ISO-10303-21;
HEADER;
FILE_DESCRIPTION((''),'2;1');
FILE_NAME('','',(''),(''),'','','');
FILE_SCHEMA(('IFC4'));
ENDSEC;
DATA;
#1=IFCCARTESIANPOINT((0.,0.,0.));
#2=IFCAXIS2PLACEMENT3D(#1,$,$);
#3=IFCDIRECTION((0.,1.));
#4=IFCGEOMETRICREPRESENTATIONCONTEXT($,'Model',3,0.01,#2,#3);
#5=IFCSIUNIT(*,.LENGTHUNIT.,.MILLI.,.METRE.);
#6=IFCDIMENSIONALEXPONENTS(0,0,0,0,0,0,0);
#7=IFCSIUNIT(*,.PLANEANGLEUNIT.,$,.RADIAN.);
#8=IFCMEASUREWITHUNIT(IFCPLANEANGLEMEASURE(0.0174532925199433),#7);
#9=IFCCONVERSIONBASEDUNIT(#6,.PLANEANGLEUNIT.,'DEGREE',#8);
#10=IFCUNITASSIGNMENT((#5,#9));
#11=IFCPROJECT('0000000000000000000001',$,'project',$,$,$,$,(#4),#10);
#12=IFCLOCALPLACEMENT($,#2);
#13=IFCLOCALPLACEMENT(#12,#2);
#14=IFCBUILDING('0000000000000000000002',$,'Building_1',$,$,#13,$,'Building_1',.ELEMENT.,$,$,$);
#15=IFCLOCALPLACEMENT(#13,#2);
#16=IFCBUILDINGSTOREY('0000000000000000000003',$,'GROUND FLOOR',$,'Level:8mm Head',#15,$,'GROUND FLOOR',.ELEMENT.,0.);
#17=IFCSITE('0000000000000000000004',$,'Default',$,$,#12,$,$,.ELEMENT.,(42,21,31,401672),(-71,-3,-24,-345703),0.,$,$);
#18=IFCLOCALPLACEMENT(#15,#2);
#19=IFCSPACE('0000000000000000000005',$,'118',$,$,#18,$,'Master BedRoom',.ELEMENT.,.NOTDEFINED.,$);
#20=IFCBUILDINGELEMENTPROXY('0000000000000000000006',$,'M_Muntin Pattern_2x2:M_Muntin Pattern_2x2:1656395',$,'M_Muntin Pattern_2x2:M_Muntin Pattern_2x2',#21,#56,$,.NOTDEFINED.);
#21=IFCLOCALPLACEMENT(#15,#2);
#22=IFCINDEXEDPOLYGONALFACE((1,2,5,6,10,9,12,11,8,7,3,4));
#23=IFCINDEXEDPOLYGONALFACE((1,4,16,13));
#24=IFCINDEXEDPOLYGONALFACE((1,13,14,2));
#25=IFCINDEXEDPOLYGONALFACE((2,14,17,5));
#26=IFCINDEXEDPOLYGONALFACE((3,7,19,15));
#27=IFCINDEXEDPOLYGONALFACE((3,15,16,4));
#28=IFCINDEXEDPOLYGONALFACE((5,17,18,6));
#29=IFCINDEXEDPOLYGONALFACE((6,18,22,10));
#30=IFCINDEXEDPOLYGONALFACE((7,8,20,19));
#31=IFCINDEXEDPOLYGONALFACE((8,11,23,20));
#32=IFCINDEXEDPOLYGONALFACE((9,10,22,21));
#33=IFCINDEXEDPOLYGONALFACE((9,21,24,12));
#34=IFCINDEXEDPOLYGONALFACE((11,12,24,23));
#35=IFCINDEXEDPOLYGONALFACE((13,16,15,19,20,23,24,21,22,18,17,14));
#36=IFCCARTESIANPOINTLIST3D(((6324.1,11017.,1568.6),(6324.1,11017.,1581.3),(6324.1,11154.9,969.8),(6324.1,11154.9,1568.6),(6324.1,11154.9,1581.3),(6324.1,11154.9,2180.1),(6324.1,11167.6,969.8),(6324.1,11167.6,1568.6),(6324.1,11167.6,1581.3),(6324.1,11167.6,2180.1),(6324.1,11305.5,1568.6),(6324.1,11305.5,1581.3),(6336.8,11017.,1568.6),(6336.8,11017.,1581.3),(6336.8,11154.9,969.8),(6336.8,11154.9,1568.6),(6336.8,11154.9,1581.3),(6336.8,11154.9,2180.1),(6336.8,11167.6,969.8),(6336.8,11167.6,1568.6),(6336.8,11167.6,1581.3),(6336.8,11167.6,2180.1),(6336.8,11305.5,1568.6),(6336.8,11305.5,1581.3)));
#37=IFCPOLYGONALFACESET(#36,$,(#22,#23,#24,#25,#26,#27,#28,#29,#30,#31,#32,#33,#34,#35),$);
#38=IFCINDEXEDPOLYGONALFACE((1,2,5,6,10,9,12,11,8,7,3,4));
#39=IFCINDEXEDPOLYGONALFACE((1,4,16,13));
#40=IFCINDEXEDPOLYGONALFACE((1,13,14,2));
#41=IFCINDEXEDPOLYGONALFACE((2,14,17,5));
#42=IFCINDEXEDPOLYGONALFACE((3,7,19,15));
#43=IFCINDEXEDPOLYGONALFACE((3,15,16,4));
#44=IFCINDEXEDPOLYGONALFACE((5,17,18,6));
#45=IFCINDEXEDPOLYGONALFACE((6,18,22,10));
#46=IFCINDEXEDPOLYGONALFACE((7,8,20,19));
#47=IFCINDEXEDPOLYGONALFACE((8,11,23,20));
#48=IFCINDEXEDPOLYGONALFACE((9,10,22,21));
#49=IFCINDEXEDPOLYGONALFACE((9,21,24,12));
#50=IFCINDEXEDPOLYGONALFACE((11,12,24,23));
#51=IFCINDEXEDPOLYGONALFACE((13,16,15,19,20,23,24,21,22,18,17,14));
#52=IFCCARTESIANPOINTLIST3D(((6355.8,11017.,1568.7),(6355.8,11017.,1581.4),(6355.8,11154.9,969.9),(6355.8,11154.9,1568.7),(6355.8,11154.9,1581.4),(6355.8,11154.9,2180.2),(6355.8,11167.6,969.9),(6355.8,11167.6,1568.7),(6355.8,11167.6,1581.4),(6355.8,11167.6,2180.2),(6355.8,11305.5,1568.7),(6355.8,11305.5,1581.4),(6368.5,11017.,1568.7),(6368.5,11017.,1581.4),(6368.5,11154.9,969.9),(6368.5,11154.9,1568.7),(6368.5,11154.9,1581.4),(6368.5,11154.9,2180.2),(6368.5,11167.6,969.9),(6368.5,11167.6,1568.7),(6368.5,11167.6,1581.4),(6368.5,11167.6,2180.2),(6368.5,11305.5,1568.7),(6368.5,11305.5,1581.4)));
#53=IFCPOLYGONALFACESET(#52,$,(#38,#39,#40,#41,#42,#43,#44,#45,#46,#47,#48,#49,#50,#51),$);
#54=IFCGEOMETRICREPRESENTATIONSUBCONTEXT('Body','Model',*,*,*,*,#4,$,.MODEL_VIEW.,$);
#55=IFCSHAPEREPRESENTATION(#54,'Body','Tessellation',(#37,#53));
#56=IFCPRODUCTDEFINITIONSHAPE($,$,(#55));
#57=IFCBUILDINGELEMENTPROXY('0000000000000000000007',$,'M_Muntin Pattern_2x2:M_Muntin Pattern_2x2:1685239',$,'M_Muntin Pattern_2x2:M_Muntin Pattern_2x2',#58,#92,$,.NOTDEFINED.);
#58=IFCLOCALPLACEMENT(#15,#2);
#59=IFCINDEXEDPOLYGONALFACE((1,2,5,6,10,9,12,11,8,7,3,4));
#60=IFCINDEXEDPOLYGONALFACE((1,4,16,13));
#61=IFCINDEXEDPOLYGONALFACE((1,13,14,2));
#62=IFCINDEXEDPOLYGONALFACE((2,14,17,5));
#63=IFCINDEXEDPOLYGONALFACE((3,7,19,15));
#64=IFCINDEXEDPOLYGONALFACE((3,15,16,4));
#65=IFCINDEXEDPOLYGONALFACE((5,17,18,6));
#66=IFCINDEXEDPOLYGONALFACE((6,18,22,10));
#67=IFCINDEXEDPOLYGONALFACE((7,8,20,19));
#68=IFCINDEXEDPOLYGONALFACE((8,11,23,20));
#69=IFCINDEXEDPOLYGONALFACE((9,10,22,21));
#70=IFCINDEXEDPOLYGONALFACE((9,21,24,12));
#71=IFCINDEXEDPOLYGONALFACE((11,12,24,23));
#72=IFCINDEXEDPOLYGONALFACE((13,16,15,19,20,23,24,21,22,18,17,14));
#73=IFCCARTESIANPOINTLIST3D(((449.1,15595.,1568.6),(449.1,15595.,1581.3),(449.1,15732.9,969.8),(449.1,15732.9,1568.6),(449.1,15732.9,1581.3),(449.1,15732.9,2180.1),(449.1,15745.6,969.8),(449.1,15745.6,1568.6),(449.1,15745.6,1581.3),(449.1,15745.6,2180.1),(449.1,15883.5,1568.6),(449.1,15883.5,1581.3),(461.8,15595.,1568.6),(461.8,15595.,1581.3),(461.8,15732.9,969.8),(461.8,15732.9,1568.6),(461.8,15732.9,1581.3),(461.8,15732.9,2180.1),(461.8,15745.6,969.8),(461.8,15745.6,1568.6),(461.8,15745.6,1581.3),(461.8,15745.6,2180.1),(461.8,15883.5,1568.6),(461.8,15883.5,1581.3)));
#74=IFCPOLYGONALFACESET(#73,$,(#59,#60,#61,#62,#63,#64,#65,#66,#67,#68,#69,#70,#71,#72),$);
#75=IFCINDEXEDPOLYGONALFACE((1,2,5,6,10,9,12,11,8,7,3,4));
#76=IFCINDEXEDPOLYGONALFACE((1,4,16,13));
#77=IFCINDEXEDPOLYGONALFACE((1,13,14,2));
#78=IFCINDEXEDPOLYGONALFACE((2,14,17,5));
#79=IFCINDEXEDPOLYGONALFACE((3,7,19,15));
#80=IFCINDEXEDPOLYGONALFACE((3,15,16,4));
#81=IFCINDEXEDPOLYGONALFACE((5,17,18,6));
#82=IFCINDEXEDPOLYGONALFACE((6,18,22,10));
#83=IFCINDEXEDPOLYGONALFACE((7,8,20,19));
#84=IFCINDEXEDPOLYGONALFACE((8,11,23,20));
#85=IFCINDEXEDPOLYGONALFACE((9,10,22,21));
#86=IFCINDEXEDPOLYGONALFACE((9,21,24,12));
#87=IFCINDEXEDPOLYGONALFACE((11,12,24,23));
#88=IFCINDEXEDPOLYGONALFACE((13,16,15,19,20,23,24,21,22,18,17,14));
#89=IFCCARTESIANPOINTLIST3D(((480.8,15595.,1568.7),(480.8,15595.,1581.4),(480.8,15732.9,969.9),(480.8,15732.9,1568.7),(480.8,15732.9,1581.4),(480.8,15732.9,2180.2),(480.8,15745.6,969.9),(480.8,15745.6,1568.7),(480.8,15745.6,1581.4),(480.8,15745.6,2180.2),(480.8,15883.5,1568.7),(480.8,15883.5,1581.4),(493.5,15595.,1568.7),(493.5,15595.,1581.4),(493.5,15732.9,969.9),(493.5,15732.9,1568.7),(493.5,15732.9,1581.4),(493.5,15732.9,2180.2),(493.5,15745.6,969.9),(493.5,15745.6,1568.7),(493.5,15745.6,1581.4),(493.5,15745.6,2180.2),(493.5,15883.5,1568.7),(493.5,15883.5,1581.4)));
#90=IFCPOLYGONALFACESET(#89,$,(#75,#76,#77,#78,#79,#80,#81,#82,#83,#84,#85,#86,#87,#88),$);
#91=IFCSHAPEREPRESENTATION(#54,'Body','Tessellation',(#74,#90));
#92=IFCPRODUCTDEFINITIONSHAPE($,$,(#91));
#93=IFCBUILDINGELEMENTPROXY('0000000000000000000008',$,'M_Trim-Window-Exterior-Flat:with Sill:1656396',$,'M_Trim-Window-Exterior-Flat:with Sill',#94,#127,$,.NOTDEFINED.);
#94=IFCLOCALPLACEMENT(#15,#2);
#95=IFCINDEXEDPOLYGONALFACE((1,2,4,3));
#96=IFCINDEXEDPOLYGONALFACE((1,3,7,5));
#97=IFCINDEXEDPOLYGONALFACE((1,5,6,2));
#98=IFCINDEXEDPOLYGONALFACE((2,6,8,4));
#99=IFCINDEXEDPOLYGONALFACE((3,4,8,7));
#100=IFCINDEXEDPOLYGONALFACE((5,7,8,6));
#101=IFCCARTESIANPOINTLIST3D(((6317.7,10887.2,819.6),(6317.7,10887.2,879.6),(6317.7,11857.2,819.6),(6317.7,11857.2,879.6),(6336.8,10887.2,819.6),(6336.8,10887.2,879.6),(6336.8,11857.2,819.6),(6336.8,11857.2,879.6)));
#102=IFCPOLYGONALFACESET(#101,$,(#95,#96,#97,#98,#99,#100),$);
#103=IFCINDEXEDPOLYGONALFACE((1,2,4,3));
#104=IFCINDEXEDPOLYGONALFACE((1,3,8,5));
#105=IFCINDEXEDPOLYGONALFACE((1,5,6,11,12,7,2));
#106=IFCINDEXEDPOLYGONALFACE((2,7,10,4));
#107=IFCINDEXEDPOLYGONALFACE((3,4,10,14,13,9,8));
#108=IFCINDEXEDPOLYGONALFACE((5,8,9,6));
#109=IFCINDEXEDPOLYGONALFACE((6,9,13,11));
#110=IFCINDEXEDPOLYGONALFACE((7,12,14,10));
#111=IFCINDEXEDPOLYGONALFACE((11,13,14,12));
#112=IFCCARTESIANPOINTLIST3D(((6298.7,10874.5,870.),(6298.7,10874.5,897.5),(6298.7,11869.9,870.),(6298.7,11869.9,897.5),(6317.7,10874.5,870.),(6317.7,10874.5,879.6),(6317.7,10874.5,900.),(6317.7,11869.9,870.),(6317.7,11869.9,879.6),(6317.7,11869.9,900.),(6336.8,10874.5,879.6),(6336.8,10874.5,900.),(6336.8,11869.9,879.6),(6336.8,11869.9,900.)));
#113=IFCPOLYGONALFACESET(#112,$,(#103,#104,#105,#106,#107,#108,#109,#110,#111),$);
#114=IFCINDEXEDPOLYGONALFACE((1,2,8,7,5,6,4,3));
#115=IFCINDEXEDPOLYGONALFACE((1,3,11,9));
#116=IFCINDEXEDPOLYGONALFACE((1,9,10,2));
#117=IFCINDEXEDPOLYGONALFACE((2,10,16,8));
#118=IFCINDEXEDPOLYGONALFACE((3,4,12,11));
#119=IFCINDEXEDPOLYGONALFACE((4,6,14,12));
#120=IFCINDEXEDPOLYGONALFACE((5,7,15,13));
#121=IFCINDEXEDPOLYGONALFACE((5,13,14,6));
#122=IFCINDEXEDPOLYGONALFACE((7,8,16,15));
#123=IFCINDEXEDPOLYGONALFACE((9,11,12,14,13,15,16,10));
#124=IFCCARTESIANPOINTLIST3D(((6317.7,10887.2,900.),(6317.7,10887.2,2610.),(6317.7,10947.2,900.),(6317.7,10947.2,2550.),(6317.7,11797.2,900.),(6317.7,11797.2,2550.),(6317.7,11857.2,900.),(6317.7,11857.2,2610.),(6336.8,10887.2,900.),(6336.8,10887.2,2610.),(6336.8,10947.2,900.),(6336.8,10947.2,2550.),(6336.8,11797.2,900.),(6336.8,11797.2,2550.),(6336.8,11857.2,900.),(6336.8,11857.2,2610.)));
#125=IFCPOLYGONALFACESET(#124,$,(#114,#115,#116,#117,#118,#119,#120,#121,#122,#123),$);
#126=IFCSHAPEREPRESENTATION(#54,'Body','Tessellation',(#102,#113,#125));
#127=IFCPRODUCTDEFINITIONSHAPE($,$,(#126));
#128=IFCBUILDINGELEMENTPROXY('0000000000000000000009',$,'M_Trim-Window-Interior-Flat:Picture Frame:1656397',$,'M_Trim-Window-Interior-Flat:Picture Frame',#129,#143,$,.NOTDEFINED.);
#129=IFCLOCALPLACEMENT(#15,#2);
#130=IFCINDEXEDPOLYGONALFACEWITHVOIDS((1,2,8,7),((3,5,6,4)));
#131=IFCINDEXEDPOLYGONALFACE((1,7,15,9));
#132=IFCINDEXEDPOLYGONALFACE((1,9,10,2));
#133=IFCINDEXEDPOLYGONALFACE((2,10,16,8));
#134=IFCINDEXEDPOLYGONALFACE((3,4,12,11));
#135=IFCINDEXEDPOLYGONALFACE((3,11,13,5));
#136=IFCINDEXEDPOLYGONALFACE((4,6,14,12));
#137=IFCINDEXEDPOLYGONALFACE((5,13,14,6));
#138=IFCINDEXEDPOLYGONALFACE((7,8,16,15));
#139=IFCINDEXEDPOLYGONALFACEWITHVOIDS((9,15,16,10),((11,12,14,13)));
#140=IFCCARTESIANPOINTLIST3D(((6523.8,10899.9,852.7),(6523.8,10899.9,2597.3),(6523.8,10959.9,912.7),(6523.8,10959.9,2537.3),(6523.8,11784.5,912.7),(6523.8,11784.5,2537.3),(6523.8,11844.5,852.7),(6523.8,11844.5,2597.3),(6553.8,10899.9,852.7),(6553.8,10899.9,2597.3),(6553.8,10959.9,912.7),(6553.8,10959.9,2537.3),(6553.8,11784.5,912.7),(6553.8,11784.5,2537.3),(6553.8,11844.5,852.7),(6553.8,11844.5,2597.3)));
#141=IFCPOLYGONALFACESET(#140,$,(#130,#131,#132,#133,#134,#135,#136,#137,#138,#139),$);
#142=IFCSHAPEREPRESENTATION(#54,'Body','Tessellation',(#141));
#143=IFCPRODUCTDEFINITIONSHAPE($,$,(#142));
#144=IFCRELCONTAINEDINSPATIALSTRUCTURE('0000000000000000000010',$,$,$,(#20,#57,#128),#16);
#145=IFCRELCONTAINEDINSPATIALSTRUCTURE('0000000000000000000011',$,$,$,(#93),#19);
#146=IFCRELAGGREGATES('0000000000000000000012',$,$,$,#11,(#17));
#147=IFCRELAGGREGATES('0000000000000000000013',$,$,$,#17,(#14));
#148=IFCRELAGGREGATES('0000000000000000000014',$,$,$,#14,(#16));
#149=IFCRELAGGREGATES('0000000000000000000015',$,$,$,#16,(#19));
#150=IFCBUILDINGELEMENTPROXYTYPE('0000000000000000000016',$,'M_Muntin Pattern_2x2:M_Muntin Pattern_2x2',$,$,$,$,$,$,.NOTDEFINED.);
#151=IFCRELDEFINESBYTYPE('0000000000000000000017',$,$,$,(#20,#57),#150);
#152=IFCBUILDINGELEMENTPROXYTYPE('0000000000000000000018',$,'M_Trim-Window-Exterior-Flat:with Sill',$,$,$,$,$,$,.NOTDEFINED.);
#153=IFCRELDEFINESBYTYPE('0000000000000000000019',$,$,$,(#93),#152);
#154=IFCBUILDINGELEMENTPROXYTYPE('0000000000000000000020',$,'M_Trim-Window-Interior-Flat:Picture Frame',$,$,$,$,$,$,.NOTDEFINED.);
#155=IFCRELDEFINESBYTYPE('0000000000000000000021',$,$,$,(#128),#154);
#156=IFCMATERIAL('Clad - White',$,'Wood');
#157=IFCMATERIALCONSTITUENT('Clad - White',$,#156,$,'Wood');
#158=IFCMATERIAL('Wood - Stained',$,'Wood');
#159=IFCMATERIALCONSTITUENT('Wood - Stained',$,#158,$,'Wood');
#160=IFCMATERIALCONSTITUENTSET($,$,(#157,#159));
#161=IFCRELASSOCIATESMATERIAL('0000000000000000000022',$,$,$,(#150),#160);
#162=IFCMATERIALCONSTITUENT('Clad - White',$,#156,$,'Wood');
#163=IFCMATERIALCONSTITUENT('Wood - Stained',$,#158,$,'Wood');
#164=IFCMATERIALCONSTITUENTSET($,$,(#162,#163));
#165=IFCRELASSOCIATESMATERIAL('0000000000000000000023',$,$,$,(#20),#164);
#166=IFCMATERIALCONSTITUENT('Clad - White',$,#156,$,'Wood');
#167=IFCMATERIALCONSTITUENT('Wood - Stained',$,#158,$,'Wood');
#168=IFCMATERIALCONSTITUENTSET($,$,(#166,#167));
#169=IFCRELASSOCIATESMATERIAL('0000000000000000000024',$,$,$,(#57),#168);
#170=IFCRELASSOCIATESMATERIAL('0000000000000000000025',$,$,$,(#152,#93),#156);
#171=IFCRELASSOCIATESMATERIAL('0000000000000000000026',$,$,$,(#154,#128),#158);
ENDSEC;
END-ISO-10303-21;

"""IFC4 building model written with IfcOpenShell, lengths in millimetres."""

from ifc_helpers import new_model, entity, si_unit, converted_unit, direction, frame, origin, place, context, subcontext, project, spatial, indexed_curve, outline, extrude, source, transform, mapped, material, constituent, constituent_set, type_object, type_shapes, element, save


model = new_model("IFC4")

# Units and contexts
model_context = context("Model", 3, precision=0.01, world=origin(), true_north=direction((0.0, 1.0)))
body_context = subcontext(model_context, "Body", "Model", "MODEL_VIEW")
ifc_project = project(units=[si_unit("LENGTHUNIT", "METRE", prefix="MILLI"), converted_unit("PLANEANGLEUNIT", "DEGREE", entity("IfcPlaneAngleMeasure", 0.0174532925199433), si_unit("PLANEANGLEUNIT", "RADIAN"), dimensions=[0, 0, 0, 0, 0, 0, 0])], contexts=[model_context])

# Site, building, storey
site_placement = place(None, origin())
site = spatial("IfcSite", under=ifc_project, at=site_placement, Name="Default", CompositionType="ELEMENT", RefLatitude=(42, 21, 31, 401672), RefLongitude=(-71, -3, -24, -345703), RefElevation=0.0)
building_placement = place(site_placement, origin())
building = spatial("IfcBuilding", under=site, at=building_placement, Name="Building_1", LongName="Building_1", CompositionType="ELEMENT")
storey_placement = place(building_placement, origin())
storey = spatial("IfcBuildingStorey", under=building, at=storey_placement, Name="GROUND FLOOR", ObjectType="Level:8mm Head", LongName="GROUND FLOOR", CompositionType="ELEMENT", Elevation=0.0)

# Shared definitions
ifc_material_1 = material(Name="Wood - Stained", Category="Wood")

# Building element proxies
ifc_material_2 = material(Name="Clad - White", Category="Wood")
ifc_constituent_1 = constituent(ifc_material_2, Name="Clad - White", Category="Wood")
ifc_constituent_2 = constituent(ifc_material_1, Name="Wood - Stained", Category="Wood")
ifc_constituent_set_1 = constituent_set(constituents=[ifc_constituent_1, ifc_constituent_2])
ifc_constituent_3 = constituent(ifc_material_2, Name="Clad - White", Category="Wood")
ifc_constituent_4 = constituent(ifc_material_1, Name="Wood - Stained", Category="Wood")
ifc_constituent_set_2 = constituent_set(constituents=[ifc_constituent_3, ifc_constituent_4])
building_element_proxy_type_1 = type_object("IfcBuildingElementProxyType", Name="M_Muntin Pattern_2x2:M_Muntin Pattern_2x2", PredefinedType="NOTDEFINED", material=ifc_constituent_set_2)
shared_shape_1 = source(origin(), body_context, "Body", "SweptSolid", [
    extrude(outline(indexed_curve([(6.4, -6.4), (605.1, -6.4), (605.1, 6.3), (6.4, 6.3), (6.4, 144.2), (-6.3, 144.2), (-6.3, 6.3), (-605.2, 6.3), (-605.2, -6.4), (-6.3, -6.4), (-6.3, -144.2), (6.4, -144.2), (6.4, -6.4)], self_intersect=False)), frame((0.0, 9.5, 605.1), z_axis=(0.0, 1.0, 0.0), x_axis=(0.0, 0.0, 1.0)), (0.0, 0.0, 1.0), 12.7),
    extrude(outline(indexed_curve([(6.4, -6.4), (605.2, -6.4), (605.2, 6.3), (6.4, 6.3), (6.4, 144.2), (-6.3, 144.2), (-6.3, 6.3), (-605.2, 6.3), (-605.2, -6.4), (-6.3, -6.4), (-6.3, -144.2), (6.4, -144.2), (6.4, -6.4)], self_intersect=False)), frame((0.0, -22.2, 605.2), z_axis=(0.0, 1.0, 0.0), x_axis=(0.0, 0.0, 1.0)), (0.0, 0.0, 1.0), 12.7),
])
type_shapes(building_element_proxy_type_1, [shared_shape_1])
proxy_1_placement = place(storey_placement, frame((6346.3, 11161.3, 969.9), z_axis=(0.0, 0.0, 1.0), x_axis=(0.0, 1.0, 0.0)))
element("IfcBuildingElementProxy", 1, at=proxy_1_placement, inside=storey, type_object=building_element_proxy_type_1, material=ifc_constituent_set_1, Name="M_Muntin Pattern_2x2:M_Muntin Pattern_2x2:1656395", ObjectType="M_Muntin Pattern_2x2:M_Muntin Pattern_2x2", PredefinedType="NOTDEFINED", context=body_context, shape_type="MappedRepresentation", body=[
    mapped(shared_shape_1, transform((0.0, 0.0, 0.0), scale=1.0)),
])
ifc_constituent_5 = constituent(ifc_material_2, Name="Clad - White", Category="Wood")
ifc_constituent_6 = constituent(ifc_material_1, Name="Wood - Stained", Category="Wood")
ifc_constituent_set_3 = constituent_set(constituents=[ifc_constituent_5, ifc_constituent_6])
proxy_2_placement = place(storey_placement, frame((471.3, 15739.3, 969.9), z_axis=(0.0, 0.0, 1.0), x_axis=(0.0, 1.0, 0.0)))
element("IfcBuildingElementProxy", 2, at=proxy_2_placement, inside=storey, type_object=building_element_proxy_type_1, material=ifc_constituent_set_3, Name="M_Muntin Pattern_2x2:M_Muntin Pattern_2x2:1685239", ObjectType="M_Muntin Pattern_2x2:M_Muntin Pattern_2x2", PredefinedType="NOTDEFINED", context=body_context, shape_type="MappedRepresentation", body=[
    mapped(shared_shape_1, transform((0.0, 0.0, 0.0), scale=1.0)),
])

# Shared definitions
space_1_placement = place(storey_placement, origin())
space_1 = spatial("IfcSpace", under=storey, at=space_1_placement, Name="118", LongName="Master BedRoom", CompositionType="ELEMENT", PredefinedType="NOTDEFINED")

# Building element proxies
building_element_proxy_type_2 = type_object("IfcBuildingElementProxyType", Name="M_Trim-Window-Exterior-Flat:with Sill", PredefinedType="NOTDEFINED", material=ifc_material_2)
shared_shape_2 = source(origin(), body_context, "Body", "SweptSolid", [
    extrude(outline(indexed_curve([(-30.0, -485.0), (30.0, -485.0), (30.0, 485.0), (-30.0, 485.0), (-30.0, -485.0)], self_intersect=False)), frame((0.0, 1700.4, 0.0), z_axis=(0.0, 0.0, 1.0), x_axis=(0.0, 1.0, 0.0)), (0.0, 0.0, 1.0), 19.1),
    extrude(outline(indexed_curve([(-15.2, -19.0), (12.3, -19.0), (14.8, 0.0), (14.8, 19.0), (-5.7, 19.0), (-5.7, 0.0), (-15.2, 0.0), (-15.2, -19.0)], self_intersect=False)), frame((-497.7, 1664.8, 19.0), z_axis=(1.0, 0.0, 0.0), x_axis=(0.0, -1.0, 0.0)), (0.0, 0.0, 1.0), 995.4),
    extrude(outline(indexed_curve([(-485.0, -870.0), (485.0, -870.0), (485.0, 840.0), (425.0, 840.0), (425.0, -810.0), (-425.0, -810.0), (-425.0, 840.0), (-485.0, 840.0), (-485.0, -870.0)], self_intersect=False)), frame((0.0, 810.0, 0.0)), (0.0, 0.0, 1.0), 19.1),
])
type_shapes(building_element_proxy_type_2, [shared_shape_2])
proxy_3_placement = place(space_1_placement, frame((6336.8, 11372.2, 2550.0), z_axis=(-1.0, 0.0, 0.0), x_axis=(0.0, 1.0, 0.0)))
element("IfcBuildingElementProxy", 3, at=proxy_3_placement, inside=space_1, type_object=building_element_proxy_type_2, material=ifc_material_2, Name="M_Trim-Window-Exterior-Flat:with Sill:1656396", ObjectType="M_Trim-Window-Exterior-Flat:with Sill", PredefinedType="NOTDEFINED", context=body_context, shape_type="MappedRepresentation", body=[
    mapped(shared_shape_2, transform((0.0, 0.0, 0.0), scale=1.0)),
])
building_element_proxy_type_3 = type_object("IfcBuildingElementProxyType", Name="M_Trim-Window-Interior-Flat:Picture Frame", PredefinedType="NOTDEFINED", material=ifc_material_1)
shared_shape_3 = source(origin(), body_context, "Body", "SweptSolid", [
    extrude(outline(indexed_curve([(-872.3, -472.3), (872.3, -472.3), (872.3, 472.3), (-872.3, 472.3), (-872.3, -472.3)], self_intersect=False), holes=[indexed_curve([(-812.3, -412.3), (-812.3, 412.3), (812.3, 412.3), (812.3, -412.3), (-812.3, -412.3)], self_intersect=False)]), frame((0.0, 825.0, 0.0), z_axis=(0.0, 0.0, 1.0), x_axis=(0.0, 1.0, 0.0)), (0.0, 0.0, 1.0), 30.0),
])
type_shapes(building_element_proxy_type_3, [shared_shape_3])
proxy_4_placement = place(storey_placement, frame((6523.8, 11372.2, 2550.0), z_axis=(1.0, 0.0, 0.0), x_axis=(0.0, -1.0, 0.0)))
element("IfcBuildingElementProxy", 4, at=proxy_4_placement, inside=storey, type_object=building_element_proxy_type_3, material=ifc_material_1, Name="M_Trim-Window-Interior-Flat:Picture Frame:1656397", ObjectType="M_Trim-Window-Interior-Flat:Picture Frame", PredefinedType="NOTDEFINED", context=body_context, shape_type="MappedRepresentation", body=[
    mapped(shared_shape_3, transform((0.0, 0.0, 0.0), scale=1.0)),
])

save(model, "model.ifc")
